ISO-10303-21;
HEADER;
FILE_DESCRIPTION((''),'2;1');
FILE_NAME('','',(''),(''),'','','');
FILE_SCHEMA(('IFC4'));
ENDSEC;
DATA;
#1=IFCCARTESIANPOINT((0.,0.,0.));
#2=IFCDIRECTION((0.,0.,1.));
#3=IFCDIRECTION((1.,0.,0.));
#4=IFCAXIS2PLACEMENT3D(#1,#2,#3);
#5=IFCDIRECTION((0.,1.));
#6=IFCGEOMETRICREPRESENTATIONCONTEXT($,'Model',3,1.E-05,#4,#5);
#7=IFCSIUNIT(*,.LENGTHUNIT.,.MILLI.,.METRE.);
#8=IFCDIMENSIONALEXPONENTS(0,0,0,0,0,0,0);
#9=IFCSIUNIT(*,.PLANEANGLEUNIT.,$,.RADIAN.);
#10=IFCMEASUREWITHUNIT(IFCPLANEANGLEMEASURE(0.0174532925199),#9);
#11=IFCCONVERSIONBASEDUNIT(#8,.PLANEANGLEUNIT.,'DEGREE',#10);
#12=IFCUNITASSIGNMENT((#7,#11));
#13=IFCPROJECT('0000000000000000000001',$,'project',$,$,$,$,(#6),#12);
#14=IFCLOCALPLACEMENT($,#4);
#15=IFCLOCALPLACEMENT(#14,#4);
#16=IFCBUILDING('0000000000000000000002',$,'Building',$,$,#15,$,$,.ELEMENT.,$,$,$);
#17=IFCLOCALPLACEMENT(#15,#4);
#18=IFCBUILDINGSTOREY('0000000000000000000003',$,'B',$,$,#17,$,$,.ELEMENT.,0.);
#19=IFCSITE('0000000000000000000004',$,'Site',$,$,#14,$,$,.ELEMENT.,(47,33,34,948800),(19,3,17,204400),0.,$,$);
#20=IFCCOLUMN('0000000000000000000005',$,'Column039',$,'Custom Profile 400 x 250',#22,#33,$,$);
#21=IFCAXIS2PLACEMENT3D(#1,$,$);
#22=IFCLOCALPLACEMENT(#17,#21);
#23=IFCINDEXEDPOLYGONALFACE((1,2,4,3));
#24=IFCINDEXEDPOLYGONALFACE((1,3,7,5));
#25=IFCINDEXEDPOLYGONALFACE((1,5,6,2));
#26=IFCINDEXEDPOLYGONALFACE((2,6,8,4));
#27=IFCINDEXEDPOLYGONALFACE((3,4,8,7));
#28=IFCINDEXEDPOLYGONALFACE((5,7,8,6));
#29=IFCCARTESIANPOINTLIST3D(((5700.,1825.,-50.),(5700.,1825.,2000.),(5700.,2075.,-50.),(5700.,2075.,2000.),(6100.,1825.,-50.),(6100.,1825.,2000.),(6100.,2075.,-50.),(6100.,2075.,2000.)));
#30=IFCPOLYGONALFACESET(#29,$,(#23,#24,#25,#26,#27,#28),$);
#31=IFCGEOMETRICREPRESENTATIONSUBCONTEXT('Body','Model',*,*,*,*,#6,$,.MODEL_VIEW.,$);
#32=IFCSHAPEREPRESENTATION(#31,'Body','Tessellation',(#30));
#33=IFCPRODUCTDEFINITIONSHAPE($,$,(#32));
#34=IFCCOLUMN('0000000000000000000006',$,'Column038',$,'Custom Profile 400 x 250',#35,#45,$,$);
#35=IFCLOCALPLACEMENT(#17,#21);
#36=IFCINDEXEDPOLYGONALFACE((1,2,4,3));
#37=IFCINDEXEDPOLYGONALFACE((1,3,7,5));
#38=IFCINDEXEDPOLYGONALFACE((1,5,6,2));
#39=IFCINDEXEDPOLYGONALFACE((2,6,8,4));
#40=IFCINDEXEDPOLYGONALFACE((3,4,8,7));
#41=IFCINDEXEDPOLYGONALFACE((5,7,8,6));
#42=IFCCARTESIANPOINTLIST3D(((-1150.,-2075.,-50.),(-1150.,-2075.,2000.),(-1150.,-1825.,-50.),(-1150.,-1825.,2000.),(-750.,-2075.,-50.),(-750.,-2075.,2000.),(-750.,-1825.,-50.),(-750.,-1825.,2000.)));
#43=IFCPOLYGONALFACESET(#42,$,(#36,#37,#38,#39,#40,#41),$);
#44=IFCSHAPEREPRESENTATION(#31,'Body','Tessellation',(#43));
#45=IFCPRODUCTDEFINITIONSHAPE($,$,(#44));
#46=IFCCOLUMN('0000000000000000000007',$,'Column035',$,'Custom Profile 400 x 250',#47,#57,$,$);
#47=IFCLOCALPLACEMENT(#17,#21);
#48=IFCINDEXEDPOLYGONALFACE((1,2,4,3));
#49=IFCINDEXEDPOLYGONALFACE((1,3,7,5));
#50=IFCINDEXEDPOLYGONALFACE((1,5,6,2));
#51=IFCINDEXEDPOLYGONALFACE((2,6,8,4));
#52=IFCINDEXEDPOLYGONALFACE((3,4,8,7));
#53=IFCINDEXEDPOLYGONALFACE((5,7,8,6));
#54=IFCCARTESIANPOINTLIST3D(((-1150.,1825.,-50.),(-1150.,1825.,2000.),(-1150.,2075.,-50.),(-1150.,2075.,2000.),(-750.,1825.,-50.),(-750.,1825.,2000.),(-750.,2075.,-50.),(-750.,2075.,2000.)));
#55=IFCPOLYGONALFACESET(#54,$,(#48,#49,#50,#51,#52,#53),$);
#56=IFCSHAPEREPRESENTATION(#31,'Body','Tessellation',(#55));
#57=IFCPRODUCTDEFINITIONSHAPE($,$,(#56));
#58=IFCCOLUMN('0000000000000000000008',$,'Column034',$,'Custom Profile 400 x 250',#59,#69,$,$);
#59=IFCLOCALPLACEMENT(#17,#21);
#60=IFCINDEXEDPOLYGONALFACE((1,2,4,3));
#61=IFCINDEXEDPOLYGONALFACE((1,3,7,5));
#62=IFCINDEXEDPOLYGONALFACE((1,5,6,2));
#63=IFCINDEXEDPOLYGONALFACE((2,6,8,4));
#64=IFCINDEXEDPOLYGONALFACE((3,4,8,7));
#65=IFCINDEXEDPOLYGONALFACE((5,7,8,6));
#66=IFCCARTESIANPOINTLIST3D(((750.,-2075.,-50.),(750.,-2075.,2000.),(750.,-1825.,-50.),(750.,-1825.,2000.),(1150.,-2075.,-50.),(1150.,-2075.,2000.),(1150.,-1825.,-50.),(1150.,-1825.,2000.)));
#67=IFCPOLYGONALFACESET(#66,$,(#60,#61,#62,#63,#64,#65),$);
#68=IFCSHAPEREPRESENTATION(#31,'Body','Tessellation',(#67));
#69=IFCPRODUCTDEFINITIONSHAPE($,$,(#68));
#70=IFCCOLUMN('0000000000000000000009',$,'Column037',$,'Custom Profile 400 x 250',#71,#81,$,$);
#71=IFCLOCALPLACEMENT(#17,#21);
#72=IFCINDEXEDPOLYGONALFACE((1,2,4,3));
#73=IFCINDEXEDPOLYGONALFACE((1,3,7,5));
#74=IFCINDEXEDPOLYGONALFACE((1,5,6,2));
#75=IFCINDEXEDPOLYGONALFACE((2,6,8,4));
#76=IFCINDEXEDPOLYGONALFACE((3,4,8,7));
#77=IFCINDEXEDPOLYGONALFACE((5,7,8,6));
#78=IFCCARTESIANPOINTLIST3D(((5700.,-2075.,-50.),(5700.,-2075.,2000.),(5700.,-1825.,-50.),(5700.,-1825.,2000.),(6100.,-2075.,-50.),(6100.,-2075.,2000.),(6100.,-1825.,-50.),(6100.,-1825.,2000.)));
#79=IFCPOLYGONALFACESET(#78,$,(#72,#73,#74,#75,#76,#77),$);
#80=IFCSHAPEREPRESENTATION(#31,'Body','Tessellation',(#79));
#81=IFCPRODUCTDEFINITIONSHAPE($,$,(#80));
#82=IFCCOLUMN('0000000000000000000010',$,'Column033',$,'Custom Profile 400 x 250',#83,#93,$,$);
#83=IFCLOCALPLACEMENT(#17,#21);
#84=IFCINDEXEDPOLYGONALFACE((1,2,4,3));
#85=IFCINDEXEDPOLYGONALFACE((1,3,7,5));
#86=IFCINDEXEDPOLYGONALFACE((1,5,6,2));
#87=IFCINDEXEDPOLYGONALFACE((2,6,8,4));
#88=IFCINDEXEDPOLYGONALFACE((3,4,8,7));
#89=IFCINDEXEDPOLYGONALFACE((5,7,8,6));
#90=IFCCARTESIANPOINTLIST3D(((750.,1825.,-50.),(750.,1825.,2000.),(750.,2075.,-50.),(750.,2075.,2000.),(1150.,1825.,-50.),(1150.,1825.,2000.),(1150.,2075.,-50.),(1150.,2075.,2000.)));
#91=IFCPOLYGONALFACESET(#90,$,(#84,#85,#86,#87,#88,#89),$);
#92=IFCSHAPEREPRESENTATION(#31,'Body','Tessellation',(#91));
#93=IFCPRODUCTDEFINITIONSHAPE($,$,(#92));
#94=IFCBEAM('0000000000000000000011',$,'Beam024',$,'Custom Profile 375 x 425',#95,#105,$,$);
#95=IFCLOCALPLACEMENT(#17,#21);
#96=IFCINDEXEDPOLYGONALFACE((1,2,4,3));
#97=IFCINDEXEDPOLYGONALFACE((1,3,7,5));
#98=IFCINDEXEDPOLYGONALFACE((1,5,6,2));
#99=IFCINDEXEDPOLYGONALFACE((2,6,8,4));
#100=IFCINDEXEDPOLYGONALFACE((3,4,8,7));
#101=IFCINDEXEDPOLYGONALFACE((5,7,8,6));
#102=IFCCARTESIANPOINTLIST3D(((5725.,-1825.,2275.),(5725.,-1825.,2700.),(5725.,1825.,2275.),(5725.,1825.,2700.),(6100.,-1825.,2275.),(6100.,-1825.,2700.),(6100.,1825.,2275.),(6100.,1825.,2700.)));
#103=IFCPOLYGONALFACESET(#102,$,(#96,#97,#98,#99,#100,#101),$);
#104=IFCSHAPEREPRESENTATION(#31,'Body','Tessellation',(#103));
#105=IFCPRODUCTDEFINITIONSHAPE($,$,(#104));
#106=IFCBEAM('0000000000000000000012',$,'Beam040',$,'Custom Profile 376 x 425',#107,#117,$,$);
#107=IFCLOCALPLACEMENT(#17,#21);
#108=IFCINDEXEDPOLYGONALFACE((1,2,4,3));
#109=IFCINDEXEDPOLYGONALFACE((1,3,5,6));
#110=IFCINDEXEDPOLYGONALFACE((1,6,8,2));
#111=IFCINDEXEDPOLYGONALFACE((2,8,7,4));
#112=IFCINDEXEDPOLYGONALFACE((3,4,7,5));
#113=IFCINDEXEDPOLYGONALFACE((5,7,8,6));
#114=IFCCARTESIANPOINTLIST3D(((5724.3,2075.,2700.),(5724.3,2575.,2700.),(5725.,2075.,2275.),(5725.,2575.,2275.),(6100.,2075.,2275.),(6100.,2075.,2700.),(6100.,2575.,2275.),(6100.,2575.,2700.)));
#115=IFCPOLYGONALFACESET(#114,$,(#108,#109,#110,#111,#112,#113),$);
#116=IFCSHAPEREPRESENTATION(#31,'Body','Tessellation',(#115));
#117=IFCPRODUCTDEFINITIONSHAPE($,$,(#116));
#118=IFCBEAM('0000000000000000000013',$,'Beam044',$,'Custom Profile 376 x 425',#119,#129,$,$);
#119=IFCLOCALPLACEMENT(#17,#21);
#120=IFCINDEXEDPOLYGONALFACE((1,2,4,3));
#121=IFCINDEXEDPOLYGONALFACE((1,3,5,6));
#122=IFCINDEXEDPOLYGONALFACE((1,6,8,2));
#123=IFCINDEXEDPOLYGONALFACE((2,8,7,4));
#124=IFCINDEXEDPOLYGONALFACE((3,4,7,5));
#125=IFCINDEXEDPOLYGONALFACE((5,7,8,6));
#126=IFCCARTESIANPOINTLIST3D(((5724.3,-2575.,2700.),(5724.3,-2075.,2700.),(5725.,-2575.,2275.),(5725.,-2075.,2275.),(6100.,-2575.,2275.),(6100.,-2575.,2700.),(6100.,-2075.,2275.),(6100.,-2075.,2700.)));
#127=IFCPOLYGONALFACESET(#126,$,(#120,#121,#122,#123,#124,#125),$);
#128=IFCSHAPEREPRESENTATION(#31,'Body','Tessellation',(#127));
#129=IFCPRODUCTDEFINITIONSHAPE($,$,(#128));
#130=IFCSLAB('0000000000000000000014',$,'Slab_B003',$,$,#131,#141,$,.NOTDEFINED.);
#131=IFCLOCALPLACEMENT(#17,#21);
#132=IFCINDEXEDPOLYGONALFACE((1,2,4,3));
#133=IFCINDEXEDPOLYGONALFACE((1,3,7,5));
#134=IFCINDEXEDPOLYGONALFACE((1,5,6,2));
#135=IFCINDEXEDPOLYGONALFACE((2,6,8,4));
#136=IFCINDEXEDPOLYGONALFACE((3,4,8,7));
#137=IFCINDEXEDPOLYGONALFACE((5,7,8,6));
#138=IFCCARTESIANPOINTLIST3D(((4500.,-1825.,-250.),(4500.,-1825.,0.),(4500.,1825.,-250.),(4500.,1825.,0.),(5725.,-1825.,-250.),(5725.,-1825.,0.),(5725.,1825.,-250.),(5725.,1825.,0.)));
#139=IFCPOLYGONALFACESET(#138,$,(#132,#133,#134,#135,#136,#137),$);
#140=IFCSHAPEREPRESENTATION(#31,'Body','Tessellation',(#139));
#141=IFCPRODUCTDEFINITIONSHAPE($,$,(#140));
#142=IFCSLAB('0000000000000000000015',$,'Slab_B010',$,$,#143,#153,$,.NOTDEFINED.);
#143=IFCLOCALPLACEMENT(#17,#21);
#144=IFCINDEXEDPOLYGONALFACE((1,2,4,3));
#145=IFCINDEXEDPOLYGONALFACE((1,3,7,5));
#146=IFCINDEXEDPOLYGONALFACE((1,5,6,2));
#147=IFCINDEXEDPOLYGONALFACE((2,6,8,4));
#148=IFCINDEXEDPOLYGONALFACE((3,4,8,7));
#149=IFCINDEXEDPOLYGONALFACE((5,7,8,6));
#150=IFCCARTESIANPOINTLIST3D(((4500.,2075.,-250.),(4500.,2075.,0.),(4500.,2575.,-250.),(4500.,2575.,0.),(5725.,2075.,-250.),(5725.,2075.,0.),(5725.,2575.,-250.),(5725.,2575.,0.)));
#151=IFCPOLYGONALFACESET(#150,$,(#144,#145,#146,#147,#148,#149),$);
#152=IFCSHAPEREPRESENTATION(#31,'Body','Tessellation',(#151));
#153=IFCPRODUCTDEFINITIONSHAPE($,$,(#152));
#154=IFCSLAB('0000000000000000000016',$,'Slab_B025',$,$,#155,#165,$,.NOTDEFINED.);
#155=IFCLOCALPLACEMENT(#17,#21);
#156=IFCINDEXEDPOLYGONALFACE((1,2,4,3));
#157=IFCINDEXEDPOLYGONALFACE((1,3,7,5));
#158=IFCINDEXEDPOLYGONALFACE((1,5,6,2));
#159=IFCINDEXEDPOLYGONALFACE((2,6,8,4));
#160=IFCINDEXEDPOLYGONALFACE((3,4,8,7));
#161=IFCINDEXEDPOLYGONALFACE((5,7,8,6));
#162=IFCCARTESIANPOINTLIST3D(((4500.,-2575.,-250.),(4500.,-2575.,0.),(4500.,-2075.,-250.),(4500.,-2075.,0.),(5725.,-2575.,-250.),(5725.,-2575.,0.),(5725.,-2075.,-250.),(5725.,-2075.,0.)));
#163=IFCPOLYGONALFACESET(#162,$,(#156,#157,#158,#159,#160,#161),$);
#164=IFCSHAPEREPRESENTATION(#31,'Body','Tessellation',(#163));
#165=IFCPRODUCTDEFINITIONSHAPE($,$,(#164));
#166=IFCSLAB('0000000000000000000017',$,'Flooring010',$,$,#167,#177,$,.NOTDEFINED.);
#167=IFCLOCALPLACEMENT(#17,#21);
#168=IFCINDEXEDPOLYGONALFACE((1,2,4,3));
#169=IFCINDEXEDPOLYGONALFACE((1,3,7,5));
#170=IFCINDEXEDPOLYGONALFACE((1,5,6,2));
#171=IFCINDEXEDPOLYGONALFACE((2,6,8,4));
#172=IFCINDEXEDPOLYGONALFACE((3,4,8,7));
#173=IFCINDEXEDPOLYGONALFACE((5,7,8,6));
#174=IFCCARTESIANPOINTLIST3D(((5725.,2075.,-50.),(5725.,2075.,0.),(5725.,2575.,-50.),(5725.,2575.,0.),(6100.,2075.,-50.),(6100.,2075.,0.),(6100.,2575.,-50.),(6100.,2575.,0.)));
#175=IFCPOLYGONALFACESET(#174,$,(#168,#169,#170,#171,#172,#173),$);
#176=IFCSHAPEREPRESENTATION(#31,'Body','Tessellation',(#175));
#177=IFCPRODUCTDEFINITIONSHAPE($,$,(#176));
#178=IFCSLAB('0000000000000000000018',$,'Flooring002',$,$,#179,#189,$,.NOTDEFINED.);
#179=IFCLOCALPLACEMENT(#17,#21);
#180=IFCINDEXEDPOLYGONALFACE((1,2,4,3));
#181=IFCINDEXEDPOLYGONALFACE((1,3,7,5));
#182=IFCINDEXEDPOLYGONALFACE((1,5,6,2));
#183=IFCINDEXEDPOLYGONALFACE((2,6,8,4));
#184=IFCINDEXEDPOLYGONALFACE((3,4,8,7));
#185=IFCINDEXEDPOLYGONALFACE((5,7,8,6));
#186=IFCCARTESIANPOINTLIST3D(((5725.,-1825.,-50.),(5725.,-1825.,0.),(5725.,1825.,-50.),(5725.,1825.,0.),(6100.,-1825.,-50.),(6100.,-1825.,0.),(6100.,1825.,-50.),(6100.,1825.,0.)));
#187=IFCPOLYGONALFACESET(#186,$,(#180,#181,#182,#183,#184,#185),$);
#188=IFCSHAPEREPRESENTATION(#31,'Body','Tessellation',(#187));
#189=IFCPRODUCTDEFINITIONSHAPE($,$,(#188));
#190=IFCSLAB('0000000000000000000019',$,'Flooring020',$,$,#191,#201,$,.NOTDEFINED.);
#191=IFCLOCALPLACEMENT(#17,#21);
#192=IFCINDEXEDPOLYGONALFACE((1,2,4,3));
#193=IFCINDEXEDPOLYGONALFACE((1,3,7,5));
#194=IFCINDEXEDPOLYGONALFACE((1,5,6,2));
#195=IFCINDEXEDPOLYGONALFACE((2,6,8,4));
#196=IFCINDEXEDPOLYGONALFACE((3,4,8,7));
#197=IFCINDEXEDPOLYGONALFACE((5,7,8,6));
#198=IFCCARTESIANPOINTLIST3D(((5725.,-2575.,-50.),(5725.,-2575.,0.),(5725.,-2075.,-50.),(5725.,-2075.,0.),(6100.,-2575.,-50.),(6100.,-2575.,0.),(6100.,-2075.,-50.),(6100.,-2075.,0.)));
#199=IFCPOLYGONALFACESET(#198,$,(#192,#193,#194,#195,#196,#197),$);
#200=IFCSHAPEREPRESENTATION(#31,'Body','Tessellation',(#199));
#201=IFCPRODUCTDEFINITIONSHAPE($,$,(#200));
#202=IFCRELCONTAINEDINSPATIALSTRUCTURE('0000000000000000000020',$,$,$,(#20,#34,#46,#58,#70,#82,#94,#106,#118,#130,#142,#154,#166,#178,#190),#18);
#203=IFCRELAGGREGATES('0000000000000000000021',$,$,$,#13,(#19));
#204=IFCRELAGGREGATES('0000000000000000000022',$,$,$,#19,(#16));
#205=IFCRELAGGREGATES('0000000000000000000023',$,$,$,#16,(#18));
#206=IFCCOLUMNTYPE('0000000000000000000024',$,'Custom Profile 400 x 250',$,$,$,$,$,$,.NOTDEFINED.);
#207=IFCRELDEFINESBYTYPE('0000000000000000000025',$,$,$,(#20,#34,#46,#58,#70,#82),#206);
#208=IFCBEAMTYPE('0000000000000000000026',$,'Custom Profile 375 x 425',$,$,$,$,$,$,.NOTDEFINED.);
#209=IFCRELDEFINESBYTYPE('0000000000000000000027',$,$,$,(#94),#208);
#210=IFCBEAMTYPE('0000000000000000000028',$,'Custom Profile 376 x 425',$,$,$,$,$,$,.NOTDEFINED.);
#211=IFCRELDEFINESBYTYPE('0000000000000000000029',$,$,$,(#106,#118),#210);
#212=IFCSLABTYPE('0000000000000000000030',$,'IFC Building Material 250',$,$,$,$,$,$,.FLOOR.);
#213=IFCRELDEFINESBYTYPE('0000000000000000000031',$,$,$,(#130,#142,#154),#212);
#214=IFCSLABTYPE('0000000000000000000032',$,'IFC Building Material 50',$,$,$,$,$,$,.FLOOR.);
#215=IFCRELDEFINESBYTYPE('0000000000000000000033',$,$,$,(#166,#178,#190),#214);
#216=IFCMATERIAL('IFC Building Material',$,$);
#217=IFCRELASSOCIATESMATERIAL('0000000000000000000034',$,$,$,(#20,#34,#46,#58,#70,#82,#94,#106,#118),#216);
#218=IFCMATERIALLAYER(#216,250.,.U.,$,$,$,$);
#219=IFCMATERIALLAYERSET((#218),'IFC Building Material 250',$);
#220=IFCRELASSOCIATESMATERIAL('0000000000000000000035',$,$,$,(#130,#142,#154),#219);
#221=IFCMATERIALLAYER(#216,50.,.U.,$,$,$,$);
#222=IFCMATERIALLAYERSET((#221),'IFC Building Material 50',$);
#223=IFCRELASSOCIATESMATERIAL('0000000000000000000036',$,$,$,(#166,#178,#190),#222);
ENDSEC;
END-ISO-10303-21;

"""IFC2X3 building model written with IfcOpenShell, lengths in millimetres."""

from ifc_helpers import new_model, entity, si_unit, converted_unit, direction, frame, origin_with_axes, place, context, subcontext, project, spatial, polyline, outline, extrude, material, layer, layer_set, layer_usage, type_object, element, save


model = new_model("IFC2X3")

# Units and contexts
model_context = context("Model", 3, precision=1e-05, world=origin_with_axes(), true_north=direction((0.0, 1.0)))
body_context = subcontext(model_context, "Body", "Model", "MODEL_VIEW")
ifc_project = project(units=[si_unit("LENGTHUNIT", "METRE", prefix="MILLI"), converted_unit("PLANEANGLEUNIT", "DEGREE", entity("IfcPlaneAngleMeasure", 0.0174532925199), si_unit("PLANEANGLEUNIT", "RADIAN"), dimensions=[0, 0, 0, 0, 0, 0, 0])], contexts=[model_context])

# Site, building, storey
site_placement = place(None, origin_with_axes())
site = spatial("IfcSite", under=ifc_project, at=site_placement, Name="Site", CompositionType="ELEMENT", RefLatitude=(47, 33, 34, 948800), RefLongitude=(19, 3, 17, 204400), RefElevation=0.0)
building_placement = place(site_placement, origin_with_axes())
building = spatial("IfcBuilding", under=site, at=building_placement, Name="Building", CompositionType="ELEMENT")
storey_placement = place(building_placement, origin_with_axes())
storey = spatial("IfcBuildingStorey", under=building, at=storey_placement, Name="B", CompositionType="ELEMENT", Elevation=0.0)

# Columns
ifc_material = material(Name="IFC Building Material")
column_type = type_object("IfcColumnType", Name="Custom Profile 400 x 250", PredefinedType="NOTDEFINED")
for number, where, z_axis, x_axis, name in (
    (1, (5900.0, 1950.0, -50.0), (0.0, 0.0, 1.0), (1.0, 0.0, 0.0), "Column039"),
    (2, (-950.0, -1950.0, -50.0), (0.0, 0.0, 1.0), (1.0, 0.0, 0.0), "Column038"),
    (3, (-950.0, 1950.0, -50.0), (0.0, 0.0, 1.0), (1.0, 0.0, 0.0), "Column035"),
    (4, (950.0, -1950.0, -50.0), (0.0, 0.0, 1.0), (1.0, 0.0, 0.0), "Column034"),
    (5, (5900.0, -1950.0, -50.0), (0.0, 0.0, 1.0), (1.0, 0.0, 0.0), "Column037"),
    (6, (950.0, 1950.0, -50.0), (0.0, 0.0, 1.0), (1.0, 0.0, 0.0), "Column033"),
):
    element("IfcColumn", number, at=place(storey_placement, frame(where, z_axis=z_axis, x_axis=x_axis)), inside=storey, type_object=column_type, material=ifc_material, Name=name, ObjectType="Custom Profile 400 x 250", context=body_context, shape_type="SweptSolid", body=[
        extrude(outline(polyline([(-200.0, -125.0), (200.0, -125.0), (200.0, 125.0), (-200.0, 125.0), (-200.0, -125.0)])), origin_with_axes(), (0.0, 0.0, 1.0), 2050.0),
    ])

# Beams
beam_type_1 = type_object("IfcBeamType", Name="Custom Profile 375 x 425", PredefinedType="NOTDEFINED")
beam_placement = place(storey_placement, frame((5912.7, -1825.0, 2487.6), z_axis=(0.0, 0.0, 1.0), x_axis=(1.0, 0.0, 0.0)))
element("IfcBeam", 7, at=beam_placement, inside=storey, type_object=beam_type_1, material=ifc_material, Name="Beam024", ObjectType="Custom Profile 375 x 425", context=body_context, shape_type="SweptSolid", body=[
    extrude(outline(polyline([(-187.7, -212.6), (187.3, -212.6), (187.3, 212.4), (-187.7, 212.4), (-187.7, -212.6)])), frame((0.0, 3650.0, 0.0), z_axis=(0.0, -1.0, 0.0), x_axis=(1.0, 0.0, 0.0)), (0.0, 0.0, 1.0), 3650.0),
])
beam_type_2 = type_object("IfcBeamType", Name="Custom Profile 376 x 425", PredefinedType="NOTDEFINED")
for number, where, z_axis, x_axis, name in (
    (8, (5912.3, 2575.0, 2487.6), (0.0, 0.0, 1.0), (-1.0, 0.0, 0.0), "Beam040"),
    (9, (5912.3, -2075.0, 2487.6), (0.0, 0.0, 1.0), (-1.0, 0.0, 0.0), "Beam044"),
):
    element("IfcBeam", number, at=place(storey_placement, frame(where, z_axis=z_axis, x_axis=x_axis)), inside=storey, type_object=beam_type_2, material=ifc_material, Name=name, ObjectType="Custom Profile 376 x 425", context=body_context, shape_type="SweptSolid", body=[
        extrude(outline(polyline([(-187.7, 212.4), (-187.7, -212.6), (187.3, -212.6), (188.0, 212.4), (-187.7, 212.4)])), frame((0.0, 500.0, 0.0), z_axis=(0.0, -1.0, 0.0), x_axis=(1.0, 0.0, 0.0)), (0.0, 0.0, 1.0), 500.0),
    ])

# Slabs
ifc_layer_1 = layer(ifc_material, 250.0, ventilated="UNKNOWN")
ifc_layer_set_1 = layer_set([ifc_layer_1], Name="IFC Building Material 250")
ifc_layer_usage_1 = layer_usage(ifc_layer_set_1, "AXIS3", "NEGATIVE", 250.0)
slab_type_1 = type_object("IfcSlabType", Name="IFC Building Material 250", PredefinedType="FLOOR")
slab_1_placement = place(storey_placement, frame((4500.0, 1825.0, 0.0), z_axis=(0.0, 0.0, 1.0), x_axis=(1.0, 0.0, 0.0)))
element("IfcSlab", 10, at=slab_1_placement, inside=storey, type_object=slab_type_1, material=ifc_layer_usage_1, Name="Slab_B003", PredefinedType="NOTDEFINED", context=body_context, shape_type="SweptSolid", body=[
    extrude(outline(polyline([(0.0, 0.0), (0.0, -3650.0), (1225.0, -3650.0), (1225.0, 0.0), (0.0, 0.0)])), frame((0.0, 0.0, -250.0), z_axis=(0.0, 0.0, 1.0), x_axis=(1.0, 0.0, 0.0)), (0.0, 0.0, 1.0), 250.0),
])
ifc_layer_usage_2 = layer_usage(ifc_layer_set_1, "AXIS3", "NEGATIVE", 250.0)
slab_2_placement = place(storey_placement, frame((4500.0, 2075.0, 0.0), z_axis=(0.0, 0.0, 1.0), x_axis=(1.0, 0.0, 0.0)))
element("IfcSlab", 11, at=slab_2_placement, inside=storey, type_object=slab_type_1, material=ifc_layer_usage_2, Name="Slab_B010", PredefinedType="NOTDEFINED", context=body_context, shape_type="SweptSolid", body=[
    extrude(outline(polyline([(0.0, 0.0), (1225.0, 0.0), (1225.0, 500.0), (0.0, 500.0), (0.0, 0.0)])), frame((0.0, 0.0, -250.0), z_axis=(0.0, 0.0, 1.0), x_axis=(1.0, 0.0, 0.0)), (0.0, 0.0, 1.0), 250.0),
])
ifc_layer_usage_3 = layer_usage(ifc_layer_set_1, "AXIS3", "NEGATIVE", 250.0)
slab_3_placement = place(storey_placement, frame((4500.0, -2075.0, 0.0), z_axis=(0.0, 0.0, 1.0), x_axis=(1.0, 0.0, 0.0)))
element("IfcSlab", 12, at=slab_3_placement, inside=storey, type_object=slab_type_1, material=ifc_layer_usage_3, Name="Slab_B025", PredefinedType="NOTDEFINED", context=body_context, shape_type="SweptSolid", body=[
    extrude(outline(polyline([(0.0, 0.0), (0.0, -500.0), (1225.0, -500.0), (1225.0, 0.0), (0.0, 0.0)])), frame((0.0, 0.0, -250.0), z_axis=(0.0, 0.0, 1.0), x_axis=(1.0, 0.0, 0.0)), (0.0, 0.0, 1.0), 250.0),
])
ifc_layer_2 = layer(ifc_material, 50.0, ventilated="UNKNOWN")
ifc_layer_set_2 = layer_set([ifc_layer_2], Name="IFC Building Material 50")
ifc_layer_usage_4 = layer_usage(ifc_layer_set_2, "AXIS3", "NEGATIVE", 50.0)
slab_type_2 = type_object("IfcSlabType", Name="IFC Building Material 50", PredefinedType="FLOOR")
slab_4_placement = place(storey_placement, frame((5725.0, 2575.0, 0.0), z_axis=(0.0, 0.0, 1.0), x_axis=(1.0, 0.0, 0.0)))
element("IfcSlab", 13, at=slab_4_placement, inside=storey, type_object=slab_type_2, material=ifc_layer_usage_4, Name="Flooring010", PredefinedType="NOTDEFINED", context=body_context, shape_type="SweptSolid", body=[
    extrude(outline(polyline([(0.0, 0.0), (0.0, -500.0), (375.0, -500.0), (375.0, 0.0), (0.0, 0.0)])), frame((0.0, 0.0, -50.0), z_axis=(0.0, 0.0, 1.0), x_axis=(1.0, 0.0, 0.0)), (0.0, 0.0, 1.0), 50.0),
])
ifc_layer_usage_5 = layer_usage(ifc_layer_set_2, "AXIS3", "NEGATIVE", 50.0)
slab_5_placement = place(storey_placement, frame((5725.0, -1825.0, 0.0), z_axis=(0.0, 0.0, 1.0), x_axis=(1.0, 0.0, 0.0)))
element("IfcSlab", 14, at=slab_5_placement, inside=storey, type_object=slab_type_2, material=ifc_layer_usage_5, Name="Flooring002", PredefinedType="NOTDEFINED", context=body_context, shape_type="SweptSolid", body=[
    extrude(outline(polyline([(0.0, 0.0), (375.0, 0.0), (375.0, 3650.0), (0.0, 3650.0), (0.0, 0.0)])), frame((0.0, 0.0, -50.0), z_axis=(0.0, 0.0, 1.0), x_axis=(1.0, 0.0, 0.0)), (0.0, 0.0, 1.0), 50.0),
])
ifc_layer_usage_6 = layer_usage(ifc_layer_set_2, "AXIS3", "NEGATIVE", 50.0)
slab_6_placement = place(storey_placement, frame((5725.0, -2575.0, 0.0), z_axis=(0.0, 0.0, 1.0), x_axis=(1.0, 0.0, 0.0)))
element("IfcSlab", 15, at=slab_6_placement, inside=storey, type_object=slab_type_2, material=ifc_layer_usage_6, Name="Flooring020", PredefinedType="NOTDEFINED", context=body_context, shape_type="SweptSolid", body=[
    extrude(outline(polyline([(0.0, 0.0), (375.0, 0.0), (375.0, 500.0), (0.0, 500.0), (0.0, 0.0)])), frame((0.0, 0.0, -50.0), z_axis=(0.0, 0.0, 1.0), x_axis=(1.0, 0.0, 0.0)), (0.0, 0.0, 1.0), 50.0),
])

save(model, "model.ifc")
